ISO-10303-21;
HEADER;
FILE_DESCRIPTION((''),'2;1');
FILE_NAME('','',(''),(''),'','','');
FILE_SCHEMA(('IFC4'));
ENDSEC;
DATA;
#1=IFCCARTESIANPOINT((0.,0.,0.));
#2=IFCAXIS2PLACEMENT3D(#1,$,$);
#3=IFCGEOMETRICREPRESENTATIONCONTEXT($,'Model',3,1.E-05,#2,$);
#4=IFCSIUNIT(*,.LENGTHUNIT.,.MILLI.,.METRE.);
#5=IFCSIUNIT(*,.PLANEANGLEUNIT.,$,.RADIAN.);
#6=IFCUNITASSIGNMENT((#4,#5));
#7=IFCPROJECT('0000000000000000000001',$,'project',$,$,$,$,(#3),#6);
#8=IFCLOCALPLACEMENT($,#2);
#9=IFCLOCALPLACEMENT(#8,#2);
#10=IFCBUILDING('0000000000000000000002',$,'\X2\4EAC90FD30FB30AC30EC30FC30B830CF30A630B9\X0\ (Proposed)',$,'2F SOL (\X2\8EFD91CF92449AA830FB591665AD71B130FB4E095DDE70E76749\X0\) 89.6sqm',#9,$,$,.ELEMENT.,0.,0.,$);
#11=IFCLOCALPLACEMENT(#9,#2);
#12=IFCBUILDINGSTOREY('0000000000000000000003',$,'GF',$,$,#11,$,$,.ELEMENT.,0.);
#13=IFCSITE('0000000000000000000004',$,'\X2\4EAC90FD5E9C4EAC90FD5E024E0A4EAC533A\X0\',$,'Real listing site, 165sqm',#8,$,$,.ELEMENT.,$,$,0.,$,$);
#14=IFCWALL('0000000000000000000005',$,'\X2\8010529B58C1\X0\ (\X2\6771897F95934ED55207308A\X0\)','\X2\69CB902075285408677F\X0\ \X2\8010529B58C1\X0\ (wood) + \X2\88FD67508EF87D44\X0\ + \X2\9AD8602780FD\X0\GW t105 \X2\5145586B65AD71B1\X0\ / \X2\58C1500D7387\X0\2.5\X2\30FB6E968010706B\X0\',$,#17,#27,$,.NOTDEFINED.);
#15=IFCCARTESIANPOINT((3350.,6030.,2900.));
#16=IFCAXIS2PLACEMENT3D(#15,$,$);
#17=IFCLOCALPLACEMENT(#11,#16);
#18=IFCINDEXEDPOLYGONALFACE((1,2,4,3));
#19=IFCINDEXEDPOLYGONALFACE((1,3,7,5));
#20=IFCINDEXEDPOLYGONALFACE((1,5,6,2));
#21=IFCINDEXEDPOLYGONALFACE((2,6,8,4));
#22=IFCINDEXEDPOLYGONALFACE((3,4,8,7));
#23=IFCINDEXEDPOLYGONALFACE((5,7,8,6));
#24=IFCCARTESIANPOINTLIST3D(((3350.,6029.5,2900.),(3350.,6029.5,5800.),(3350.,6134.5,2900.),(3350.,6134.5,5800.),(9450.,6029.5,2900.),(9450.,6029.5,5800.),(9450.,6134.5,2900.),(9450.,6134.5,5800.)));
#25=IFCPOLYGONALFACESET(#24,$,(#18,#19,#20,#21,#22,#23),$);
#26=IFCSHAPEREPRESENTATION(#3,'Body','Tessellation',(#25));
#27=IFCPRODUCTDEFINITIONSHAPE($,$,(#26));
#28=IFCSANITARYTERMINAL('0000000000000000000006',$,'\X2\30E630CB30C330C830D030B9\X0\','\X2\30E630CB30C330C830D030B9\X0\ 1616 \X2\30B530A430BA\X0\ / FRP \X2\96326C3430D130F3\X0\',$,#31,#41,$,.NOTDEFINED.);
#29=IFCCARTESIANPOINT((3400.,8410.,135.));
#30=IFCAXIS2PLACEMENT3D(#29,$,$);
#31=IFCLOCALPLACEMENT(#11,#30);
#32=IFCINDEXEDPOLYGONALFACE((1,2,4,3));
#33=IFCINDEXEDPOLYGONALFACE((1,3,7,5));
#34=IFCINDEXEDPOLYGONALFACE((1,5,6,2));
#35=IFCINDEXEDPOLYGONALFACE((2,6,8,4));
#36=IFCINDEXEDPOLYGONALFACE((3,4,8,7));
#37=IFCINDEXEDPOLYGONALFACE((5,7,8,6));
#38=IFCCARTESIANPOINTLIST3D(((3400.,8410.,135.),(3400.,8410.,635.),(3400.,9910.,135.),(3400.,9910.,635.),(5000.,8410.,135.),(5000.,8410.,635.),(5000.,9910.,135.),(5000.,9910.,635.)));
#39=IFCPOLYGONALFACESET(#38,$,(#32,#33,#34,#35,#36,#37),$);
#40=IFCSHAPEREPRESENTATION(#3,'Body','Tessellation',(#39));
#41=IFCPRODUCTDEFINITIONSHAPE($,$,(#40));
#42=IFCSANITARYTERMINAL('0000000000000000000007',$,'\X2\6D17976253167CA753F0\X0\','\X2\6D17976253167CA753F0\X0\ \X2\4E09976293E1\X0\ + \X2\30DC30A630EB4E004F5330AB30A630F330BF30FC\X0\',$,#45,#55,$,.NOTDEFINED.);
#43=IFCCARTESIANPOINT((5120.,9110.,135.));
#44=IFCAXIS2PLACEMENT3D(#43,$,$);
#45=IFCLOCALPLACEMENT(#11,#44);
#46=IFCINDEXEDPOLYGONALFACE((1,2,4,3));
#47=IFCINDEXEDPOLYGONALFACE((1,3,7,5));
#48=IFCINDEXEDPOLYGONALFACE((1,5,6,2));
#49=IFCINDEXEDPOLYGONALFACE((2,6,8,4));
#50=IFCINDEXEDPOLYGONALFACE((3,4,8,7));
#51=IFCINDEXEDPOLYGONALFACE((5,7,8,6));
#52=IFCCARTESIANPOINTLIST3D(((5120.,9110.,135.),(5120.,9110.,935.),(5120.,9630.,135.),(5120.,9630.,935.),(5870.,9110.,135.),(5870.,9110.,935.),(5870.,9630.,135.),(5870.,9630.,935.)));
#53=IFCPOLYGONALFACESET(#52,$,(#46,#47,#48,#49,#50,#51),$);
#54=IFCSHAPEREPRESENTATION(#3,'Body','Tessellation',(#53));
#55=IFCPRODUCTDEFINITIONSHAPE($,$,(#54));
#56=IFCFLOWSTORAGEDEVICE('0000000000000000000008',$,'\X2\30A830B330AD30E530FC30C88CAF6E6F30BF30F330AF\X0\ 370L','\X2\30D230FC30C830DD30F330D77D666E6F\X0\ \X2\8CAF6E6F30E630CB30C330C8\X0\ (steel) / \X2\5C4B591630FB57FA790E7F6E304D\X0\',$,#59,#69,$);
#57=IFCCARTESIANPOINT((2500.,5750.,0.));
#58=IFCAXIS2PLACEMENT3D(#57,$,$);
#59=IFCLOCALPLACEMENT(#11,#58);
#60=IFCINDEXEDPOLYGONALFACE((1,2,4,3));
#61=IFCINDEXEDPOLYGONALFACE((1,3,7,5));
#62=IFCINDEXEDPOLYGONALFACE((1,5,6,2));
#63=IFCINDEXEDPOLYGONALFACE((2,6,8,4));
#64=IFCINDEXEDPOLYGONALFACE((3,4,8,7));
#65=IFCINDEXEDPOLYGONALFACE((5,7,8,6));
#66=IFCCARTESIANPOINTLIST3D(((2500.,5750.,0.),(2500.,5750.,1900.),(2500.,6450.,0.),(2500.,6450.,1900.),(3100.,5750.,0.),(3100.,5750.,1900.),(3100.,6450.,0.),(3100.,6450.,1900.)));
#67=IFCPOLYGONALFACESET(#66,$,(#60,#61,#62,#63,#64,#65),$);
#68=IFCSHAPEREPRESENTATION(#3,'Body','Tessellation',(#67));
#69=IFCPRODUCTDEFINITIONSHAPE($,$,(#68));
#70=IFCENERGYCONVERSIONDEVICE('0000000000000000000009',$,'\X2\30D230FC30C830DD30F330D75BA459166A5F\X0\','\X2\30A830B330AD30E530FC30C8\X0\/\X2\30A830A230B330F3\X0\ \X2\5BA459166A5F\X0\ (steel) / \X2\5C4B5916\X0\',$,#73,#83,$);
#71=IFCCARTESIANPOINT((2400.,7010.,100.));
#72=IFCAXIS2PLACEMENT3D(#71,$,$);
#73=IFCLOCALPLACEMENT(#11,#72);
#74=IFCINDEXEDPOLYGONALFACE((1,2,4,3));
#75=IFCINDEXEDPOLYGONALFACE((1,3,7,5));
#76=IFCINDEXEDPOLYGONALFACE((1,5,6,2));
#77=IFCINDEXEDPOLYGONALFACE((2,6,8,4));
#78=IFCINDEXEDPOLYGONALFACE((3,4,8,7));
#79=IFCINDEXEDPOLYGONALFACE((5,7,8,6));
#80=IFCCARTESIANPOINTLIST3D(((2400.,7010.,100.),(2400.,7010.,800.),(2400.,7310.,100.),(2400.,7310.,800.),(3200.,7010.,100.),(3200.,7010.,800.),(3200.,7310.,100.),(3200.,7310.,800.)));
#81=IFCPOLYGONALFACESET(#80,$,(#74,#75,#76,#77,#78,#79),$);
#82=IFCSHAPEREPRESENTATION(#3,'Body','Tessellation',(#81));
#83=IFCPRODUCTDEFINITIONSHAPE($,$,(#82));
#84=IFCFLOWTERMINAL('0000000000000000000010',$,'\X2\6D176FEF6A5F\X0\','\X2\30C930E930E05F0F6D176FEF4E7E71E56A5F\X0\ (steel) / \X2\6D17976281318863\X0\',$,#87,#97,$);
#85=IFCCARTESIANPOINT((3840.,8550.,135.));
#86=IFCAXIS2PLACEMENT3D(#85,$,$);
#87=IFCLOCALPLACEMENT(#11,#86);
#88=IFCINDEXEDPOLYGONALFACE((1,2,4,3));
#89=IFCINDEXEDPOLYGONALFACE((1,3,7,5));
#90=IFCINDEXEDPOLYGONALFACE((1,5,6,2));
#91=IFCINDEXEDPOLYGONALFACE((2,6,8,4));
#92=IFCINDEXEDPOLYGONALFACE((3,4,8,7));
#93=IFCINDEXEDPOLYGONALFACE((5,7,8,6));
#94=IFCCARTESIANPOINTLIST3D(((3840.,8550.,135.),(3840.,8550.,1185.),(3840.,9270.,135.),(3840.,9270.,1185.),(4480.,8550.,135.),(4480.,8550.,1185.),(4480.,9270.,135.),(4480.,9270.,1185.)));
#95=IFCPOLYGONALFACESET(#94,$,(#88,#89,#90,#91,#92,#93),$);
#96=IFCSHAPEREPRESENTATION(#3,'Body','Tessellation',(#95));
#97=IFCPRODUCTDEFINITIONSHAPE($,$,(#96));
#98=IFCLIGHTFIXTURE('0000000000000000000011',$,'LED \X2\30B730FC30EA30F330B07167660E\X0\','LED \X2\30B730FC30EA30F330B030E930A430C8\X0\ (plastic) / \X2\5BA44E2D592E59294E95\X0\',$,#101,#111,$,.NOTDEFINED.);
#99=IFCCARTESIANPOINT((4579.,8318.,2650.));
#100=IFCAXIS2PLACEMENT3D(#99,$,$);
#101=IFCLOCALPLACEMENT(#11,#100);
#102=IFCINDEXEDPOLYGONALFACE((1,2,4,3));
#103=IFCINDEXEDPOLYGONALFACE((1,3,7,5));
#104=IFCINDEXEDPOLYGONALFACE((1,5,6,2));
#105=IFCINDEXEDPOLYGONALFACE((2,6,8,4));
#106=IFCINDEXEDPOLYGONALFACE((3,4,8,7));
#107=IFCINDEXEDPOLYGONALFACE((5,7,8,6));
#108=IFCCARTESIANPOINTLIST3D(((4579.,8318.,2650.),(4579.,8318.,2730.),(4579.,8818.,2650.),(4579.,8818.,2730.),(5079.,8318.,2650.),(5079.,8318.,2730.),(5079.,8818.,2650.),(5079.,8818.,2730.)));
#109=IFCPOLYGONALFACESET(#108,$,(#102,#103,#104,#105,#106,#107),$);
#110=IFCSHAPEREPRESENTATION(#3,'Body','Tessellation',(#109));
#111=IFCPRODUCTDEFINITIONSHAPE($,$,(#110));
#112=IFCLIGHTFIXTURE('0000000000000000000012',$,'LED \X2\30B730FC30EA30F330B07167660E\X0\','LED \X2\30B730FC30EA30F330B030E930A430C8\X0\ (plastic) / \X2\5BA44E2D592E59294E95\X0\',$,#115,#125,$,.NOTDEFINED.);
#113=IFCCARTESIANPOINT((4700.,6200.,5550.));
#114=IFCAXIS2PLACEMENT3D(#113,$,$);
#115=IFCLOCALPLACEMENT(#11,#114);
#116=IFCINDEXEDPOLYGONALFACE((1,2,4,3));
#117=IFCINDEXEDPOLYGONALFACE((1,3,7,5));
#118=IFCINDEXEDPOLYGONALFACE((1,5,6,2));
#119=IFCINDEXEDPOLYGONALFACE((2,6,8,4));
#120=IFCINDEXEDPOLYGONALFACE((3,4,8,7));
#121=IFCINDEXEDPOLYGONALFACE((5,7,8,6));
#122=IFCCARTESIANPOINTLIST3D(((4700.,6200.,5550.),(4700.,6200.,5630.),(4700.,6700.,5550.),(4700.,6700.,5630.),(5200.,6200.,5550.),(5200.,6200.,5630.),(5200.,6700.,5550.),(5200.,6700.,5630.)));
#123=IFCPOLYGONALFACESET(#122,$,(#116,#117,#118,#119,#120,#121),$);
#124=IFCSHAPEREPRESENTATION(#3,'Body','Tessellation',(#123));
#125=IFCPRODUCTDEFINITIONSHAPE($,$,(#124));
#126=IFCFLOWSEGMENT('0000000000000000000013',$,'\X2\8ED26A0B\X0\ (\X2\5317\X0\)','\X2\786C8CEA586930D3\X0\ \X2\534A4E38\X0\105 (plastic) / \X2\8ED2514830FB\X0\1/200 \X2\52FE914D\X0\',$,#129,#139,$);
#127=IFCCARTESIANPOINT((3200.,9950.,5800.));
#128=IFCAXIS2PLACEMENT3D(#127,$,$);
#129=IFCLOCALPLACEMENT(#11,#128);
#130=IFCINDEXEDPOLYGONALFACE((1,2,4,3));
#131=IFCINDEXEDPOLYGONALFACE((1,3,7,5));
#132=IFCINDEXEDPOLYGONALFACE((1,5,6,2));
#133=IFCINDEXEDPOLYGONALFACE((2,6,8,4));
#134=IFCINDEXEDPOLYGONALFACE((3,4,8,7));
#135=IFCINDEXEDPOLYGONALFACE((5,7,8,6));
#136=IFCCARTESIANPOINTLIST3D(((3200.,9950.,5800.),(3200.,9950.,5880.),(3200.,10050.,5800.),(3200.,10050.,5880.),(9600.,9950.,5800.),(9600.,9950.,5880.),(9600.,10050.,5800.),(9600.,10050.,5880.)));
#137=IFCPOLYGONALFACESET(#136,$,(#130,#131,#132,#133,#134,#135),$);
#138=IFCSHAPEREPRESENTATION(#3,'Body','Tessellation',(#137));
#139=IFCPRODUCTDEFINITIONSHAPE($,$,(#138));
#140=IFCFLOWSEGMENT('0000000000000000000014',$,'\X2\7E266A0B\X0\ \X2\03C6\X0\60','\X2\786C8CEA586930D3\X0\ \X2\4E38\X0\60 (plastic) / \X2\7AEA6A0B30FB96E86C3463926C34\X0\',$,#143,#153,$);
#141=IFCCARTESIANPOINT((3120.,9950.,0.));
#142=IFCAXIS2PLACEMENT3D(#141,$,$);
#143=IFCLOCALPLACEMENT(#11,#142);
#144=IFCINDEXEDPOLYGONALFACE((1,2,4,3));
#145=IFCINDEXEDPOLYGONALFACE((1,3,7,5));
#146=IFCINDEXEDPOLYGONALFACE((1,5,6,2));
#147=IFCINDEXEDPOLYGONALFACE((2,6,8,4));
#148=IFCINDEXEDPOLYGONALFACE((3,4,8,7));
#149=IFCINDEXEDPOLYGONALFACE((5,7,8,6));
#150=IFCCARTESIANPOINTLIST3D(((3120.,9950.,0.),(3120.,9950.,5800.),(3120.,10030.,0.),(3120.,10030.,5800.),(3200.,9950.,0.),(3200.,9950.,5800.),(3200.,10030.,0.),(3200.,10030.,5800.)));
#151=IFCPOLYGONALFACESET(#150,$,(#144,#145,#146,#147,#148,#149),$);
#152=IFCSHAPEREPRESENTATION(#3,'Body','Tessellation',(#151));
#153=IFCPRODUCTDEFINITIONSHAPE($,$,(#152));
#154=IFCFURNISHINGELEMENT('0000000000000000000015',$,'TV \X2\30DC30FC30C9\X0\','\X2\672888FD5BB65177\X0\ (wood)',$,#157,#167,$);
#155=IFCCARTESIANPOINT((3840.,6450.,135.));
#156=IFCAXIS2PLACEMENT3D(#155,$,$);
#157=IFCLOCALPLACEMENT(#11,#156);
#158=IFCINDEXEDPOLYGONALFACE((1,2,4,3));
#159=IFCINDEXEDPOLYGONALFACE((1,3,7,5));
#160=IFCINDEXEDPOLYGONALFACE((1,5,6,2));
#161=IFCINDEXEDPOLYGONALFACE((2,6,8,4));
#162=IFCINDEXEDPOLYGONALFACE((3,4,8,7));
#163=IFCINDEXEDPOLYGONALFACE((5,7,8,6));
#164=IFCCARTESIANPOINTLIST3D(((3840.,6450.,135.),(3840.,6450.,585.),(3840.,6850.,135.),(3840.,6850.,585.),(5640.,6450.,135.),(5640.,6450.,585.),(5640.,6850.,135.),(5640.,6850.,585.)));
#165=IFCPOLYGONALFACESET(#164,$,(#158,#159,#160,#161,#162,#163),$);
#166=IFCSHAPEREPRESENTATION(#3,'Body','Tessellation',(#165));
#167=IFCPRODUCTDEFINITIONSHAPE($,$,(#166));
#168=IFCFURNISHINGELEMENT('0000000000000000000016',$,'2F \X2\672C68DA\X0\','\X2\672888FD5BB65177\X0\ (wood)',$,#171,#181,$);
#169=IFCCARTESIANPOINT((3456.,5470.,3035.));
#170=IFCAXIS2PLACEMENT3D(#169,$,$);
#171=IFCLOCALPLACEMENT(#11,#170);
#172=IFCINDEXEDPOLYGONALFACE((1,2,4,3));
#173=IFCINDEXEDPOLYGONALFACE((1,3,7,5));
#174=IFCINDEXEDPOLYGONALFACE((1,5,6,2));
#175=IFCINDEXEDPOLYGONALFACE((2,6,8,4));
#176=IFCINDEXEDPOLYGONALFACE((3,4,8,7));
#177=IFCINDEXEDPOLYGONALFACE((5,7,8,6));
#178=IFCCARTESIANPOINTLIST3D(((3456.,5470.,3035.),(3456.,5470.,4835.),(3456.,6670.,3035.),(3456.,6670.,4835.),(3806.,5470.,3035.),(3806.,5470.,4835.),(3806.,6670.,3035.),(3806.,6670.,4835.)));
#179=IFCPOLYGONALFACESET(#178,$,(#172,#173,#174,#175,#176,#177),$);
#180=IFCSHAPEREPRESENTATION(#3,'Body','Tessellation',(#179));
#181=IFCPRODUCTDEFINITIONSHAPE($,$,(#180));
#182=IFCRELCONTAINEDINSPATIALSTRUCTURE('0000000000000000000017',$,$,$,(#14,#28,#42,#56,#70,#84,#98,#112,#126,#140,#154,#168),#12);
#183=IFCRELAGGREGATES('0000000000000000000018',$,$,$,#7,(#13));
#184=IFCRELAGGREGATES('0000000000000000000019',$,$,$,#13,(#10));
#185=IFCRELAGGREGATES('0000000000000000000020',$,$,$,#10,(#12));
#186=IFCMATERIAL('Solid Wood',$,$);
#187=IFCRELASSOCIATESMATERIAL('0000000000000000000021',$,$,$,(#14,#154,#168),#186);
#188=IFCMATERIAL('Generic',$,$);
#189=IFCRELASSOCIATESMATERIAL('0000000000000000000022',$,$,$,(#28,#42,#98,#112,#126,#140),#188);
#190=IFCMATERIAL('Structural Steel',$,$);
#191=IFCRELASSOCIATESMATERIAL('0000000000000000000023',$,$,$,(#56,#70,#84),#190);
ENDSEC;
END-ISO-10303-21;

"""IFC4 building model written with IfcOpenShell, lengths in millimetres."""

from ifc_helpers import new_model, si_unit, frame, frame_2d, origin, place, context, project, spatial, rectangle, extrude, material, element, save


model = new_model("IFC4")

# Units and contexts
model_context = context("Model", 3, precision=1e-05, world=origin())
ifc_project = project(units=[si_unit("LENGTHUNIT", "METRE", prefix="MILLI"), si_unit("PLANEANGLEUNIT", "RADIAN")], contexts=[model_context])

# Site, building, storey
site_placement = place(None, origin())
site = spatial("IfcSite", under=ifc_project, at=site_placement, Name="京都府京都市上京区", ObjectType="Real listing site, 165sqm", CompositionType="ELEMENT", RefElevation=0.0)
building_placement = place(site_placement, origin())
building = spatial("IfcBuilding", under=site, at=building_placement, Name="京都・ガレージハウス (Proposed)", ObjectType="2F SOL (軽量鉄骨・外断熱・三州烧杉) 89.6sqm", CompositionType="ELEMENT", ElevationOfRefHeight=0.0, ElevationOfTerrain=0.0)
storey_placement = place(building_placement, origin())
storey = spatial("IfcBuildingStorey", under=building, at=storey_placement, Name="GF", CompositionType="ELEMENT", Elevation=0.0)

# Shared definitions
ifc_material_1 = material(Name="Solid Wood")

# Wall
wall_1_placement = place(storey_placement, frame((3350.0, 6030.0, 2900.0)))
element("IfcWall", 1, at=wall_1_placement, inside=storey, material=ifc_material_1, Name="耐力壁 (東西間仕切り)", Description="構造用合板 耐力壁 (wood) + 製材軸組 + 高性能GW t105 充填断熱 / 壁倍率2.5・準耐火", PredefinedType="NOTDEFINED", context=model_context, shape_type="SweptSolid", body=[
    extrude(rectangle(XDim=6100.0, YDim=105.0, at=frame_2d((3050.0, 52.0))), frame((3350.0, 6030.0, 2900.0)), (0.0, 0.0, 1.0), 2900.0),
])

# Sanitary terminals
ifc_material_2 = material(Name="Generic")
sanitary_terminal_1_placement = place(storey_placement, frame((3400.0, 8410.0, 135.0)))
element("IfcSanitaryTerminal", 2, at=sanitary_terminal_1_placement, inside=storey, material=ifc_material_2, Name="ユニットバス", Description="ユニットバス 1616 サイズ / FRP 防水パン", PredefinedType="NOTDEFINED", context=model_context, shape_type="SweptSolid", body=[
    extrude(rectangle(XDim=1600.0, YDim=1500.0, at=frame_2d((800.0, 750.0))), frame((3400.0, 8410.0, 135.0)), (0.0, 0.0, 1.0), 500.0),
])
sanitary_terminal_2_placement = place(storey_placement, frame((5120.0, 9110.0, 135.0)))
element("IfcSanitaryTerminal", 3, at=sanitary_terminal_2_placement, inside=storey, material=ifc_material_2, Name="洗面化粧台", Description="洗面化粧台 三面鏡 + ボウル一体カウンター", PredefinedType="NOTDEFINED", context=model_context, shape_type="SweptSolid", body=[
    extrude(rectangle(XDim=750.0, YDim=520.0, at=frame_2d((375.0, 260.0))), frame((5120.0, 9110.0, 135.0)), (0.0, 0.0, 1.0), 800.0),
])

# Flow storage device
ifc_material_3 = material(Name="Structural Steel")
flow_storage_device_placement = place(storey_placement, frame((2500.0, 5750.0, 0.0)))
element("IfcFlowStorageDevice", 4, at=flow_storage_device_placement, inside=storey, material=ifc_material_3, Name="エコキュート貯湯タンク 370L", Description="ヒートポンプ給湯 貯湯ユニット (steel) / 屋外・基礎置き", context=model_context, shape_type="SweptSolid", body=[
    extrude(rectangle(XDim=600.0, YDim=700.0, at=frame_2d((300.0, 350.0))), frame((2500.0, 5750.0, 0.0)), (0.0, 0.0, 1.0), 1900.0),
])

# Energy conversion device
energy_conversion_device_placement = place(storey_placement, frame((2400.0, 7010.0, 100.0)))
element("IfcEnergyConversionDevice", 5, at=energy_conversion_device_placement, inside=storey, material=ifc_material_3, Name="ヒートポンプ室外機", Description="エコキュート/エアコン 室外機 (steel) / 屋外", context=model_context, shape_type="SweptSolid", body=[
    extrude(rectangle(XDim=800.0, YDim=300.0, at=frame_2d((400.0, 150.0))), frame((2400.0, 7010.0, 100.0)), (0.0, 0.0, 1.0), 700.0),
])

# Flow terminal
flow_terminal_placement = place(storey_placement, frame((3840.0, 8550.0, 135.0)))
element("IfcFlowTerminal", 6, at=flow_terminal_placement, inside=storey, material=ifc_material_3, Name="洗濯機", Description="ドラム式洗濯乾燥機 (steel) / 洗面脱衣", context=model_context, shape_type="SweptSolid", body=[
    extrude(rectangle(XDim=640.0, YDim=720.0, at=frame_2d((320.0, 360.0))), frame((3840.0, 8550.0, 135.0)), (0.0, 0.0, 1.0), 1050.0),
])

# Light fixtures
light_fixture_1_placement = place(storey_placement, frame((4579.0, 8318.0, 2650.0)))
element("IfcLightFixture", 7, at=light_fixture_1_placement, inside=storey, material=ifc_material_2, Name="LED シーリング照明", Description="LED シーリングライト (plastic) / 室中央天井", PredefinedType="NOTDEFINED", context=model_context, shape_type="SweptSolid", body=[
    extrude(rectangle(XDim=500.0, YDim=500.0, at=frame_2d((250.0, 250.0))), frame((4579.0, 8318.0, 2650.0)), (0.0, 0.0, 1.0), 80.0),
])
light_fixture_2_placement = place(storey_placement, frame((4700.0, 6200.0, 5550.0)))
element("IfcLightFixture", 8, at=light_fixture_2_placement, inside=storey, material=ifc_material_2, Name="LED シーリング照明", Description="LED シーリングライト (plastic) / 室中央天井", PredefinedType="NOTDEFINED", context=model_context, shape_type="SweptSolid", body=[
    extrude(rectangle(XDim=500.0, YDim=500.0, at=frame_2d((250.0, 250.0))), frame((4700.0, 6200.0, 5550.0)), (0.0, 0.0, 1.0), 80.0),
])

# Flow segments
flow_segment_1_placement = place(storey_placement, frame((3200.0, 9950.0, 5800.0)))
element("IfcFlowSegment", 9, at=flow_segment_1_placement, inside=storey, material=ifc_material_2, Name="軒樋 (北)", Description="硬質塩ビ 半丸105 (plastic) / 軒先・1/200 勾配", context=model_context, shape_type="SweptSolid", body=[
    extrude(rectangle(XDim=6400.0, YDim=100.0, at=frame_2d((3200.0, 50.0))), frame((3200.0, 9950.0, 5800.0)), (0.0, 0.0, 1.0), 80.0),
])
flow_segment_2_placement = place(storey_placement, frame((3120.0, 9950.0, 0.0)))
element("IfcFlowSegment", 10, at=flow_segment_2_placement, inside=storey, material=ifc_material_2, Name="縦樋 φ60", Description="硬質塩ビ 丸60 (plastic) / 竪樋・雨水排水", context=model_context, shape_type="SweptSolid", body=[
    extrude(rectangle(XDim=80.0, YDim=80.0, at=frame_2d((40.0, 40.0))), frame((3120.0, 9950.0, 0.0)), (0.0, 0.0, 1.0), 5800.0),
])

# Furnishing elements
furnishing_1_placement = place(storey_placement, frame((3840.0, 6450.0, 135.0)))
element("IfcFurnishingElement", 11, at=furnishing_1_placement, inside=storey, material=ifc_material_1, Name="TV ボード", Description="木製家具 (wood)", context=model_context, shape_type="SweptSolid", body=[
    extrude(rectangle(XDim=1800.0, YDim=400.0, at=frame_2d((900.0, 200.0))), frame((3840.0, 6450.0, 135.0)), (0.0, 0.0, 1.0), 450.0),
])
furnishing_2_placement = place(storey_placement, frame((3456.0, 5470.0, 3035.0)))
element("IfcFurnishingElement", 12, at=furnishing_2_placement, inside=storey, material=ifc_material_1, Name="2F 本棚", Description="木製家具 (wood)", context=model_context, shape_type="SweptSolid", body=[
    extrude(rectangle(XDim=350.0, YDim=1200.0, at=frame_2d((175.0, 600.0))), frame((3456.0, 5470.0, 3035.0)), (0.0, 0.0, 1.0), 1800.0),
])

save(model, "model.ifc")
